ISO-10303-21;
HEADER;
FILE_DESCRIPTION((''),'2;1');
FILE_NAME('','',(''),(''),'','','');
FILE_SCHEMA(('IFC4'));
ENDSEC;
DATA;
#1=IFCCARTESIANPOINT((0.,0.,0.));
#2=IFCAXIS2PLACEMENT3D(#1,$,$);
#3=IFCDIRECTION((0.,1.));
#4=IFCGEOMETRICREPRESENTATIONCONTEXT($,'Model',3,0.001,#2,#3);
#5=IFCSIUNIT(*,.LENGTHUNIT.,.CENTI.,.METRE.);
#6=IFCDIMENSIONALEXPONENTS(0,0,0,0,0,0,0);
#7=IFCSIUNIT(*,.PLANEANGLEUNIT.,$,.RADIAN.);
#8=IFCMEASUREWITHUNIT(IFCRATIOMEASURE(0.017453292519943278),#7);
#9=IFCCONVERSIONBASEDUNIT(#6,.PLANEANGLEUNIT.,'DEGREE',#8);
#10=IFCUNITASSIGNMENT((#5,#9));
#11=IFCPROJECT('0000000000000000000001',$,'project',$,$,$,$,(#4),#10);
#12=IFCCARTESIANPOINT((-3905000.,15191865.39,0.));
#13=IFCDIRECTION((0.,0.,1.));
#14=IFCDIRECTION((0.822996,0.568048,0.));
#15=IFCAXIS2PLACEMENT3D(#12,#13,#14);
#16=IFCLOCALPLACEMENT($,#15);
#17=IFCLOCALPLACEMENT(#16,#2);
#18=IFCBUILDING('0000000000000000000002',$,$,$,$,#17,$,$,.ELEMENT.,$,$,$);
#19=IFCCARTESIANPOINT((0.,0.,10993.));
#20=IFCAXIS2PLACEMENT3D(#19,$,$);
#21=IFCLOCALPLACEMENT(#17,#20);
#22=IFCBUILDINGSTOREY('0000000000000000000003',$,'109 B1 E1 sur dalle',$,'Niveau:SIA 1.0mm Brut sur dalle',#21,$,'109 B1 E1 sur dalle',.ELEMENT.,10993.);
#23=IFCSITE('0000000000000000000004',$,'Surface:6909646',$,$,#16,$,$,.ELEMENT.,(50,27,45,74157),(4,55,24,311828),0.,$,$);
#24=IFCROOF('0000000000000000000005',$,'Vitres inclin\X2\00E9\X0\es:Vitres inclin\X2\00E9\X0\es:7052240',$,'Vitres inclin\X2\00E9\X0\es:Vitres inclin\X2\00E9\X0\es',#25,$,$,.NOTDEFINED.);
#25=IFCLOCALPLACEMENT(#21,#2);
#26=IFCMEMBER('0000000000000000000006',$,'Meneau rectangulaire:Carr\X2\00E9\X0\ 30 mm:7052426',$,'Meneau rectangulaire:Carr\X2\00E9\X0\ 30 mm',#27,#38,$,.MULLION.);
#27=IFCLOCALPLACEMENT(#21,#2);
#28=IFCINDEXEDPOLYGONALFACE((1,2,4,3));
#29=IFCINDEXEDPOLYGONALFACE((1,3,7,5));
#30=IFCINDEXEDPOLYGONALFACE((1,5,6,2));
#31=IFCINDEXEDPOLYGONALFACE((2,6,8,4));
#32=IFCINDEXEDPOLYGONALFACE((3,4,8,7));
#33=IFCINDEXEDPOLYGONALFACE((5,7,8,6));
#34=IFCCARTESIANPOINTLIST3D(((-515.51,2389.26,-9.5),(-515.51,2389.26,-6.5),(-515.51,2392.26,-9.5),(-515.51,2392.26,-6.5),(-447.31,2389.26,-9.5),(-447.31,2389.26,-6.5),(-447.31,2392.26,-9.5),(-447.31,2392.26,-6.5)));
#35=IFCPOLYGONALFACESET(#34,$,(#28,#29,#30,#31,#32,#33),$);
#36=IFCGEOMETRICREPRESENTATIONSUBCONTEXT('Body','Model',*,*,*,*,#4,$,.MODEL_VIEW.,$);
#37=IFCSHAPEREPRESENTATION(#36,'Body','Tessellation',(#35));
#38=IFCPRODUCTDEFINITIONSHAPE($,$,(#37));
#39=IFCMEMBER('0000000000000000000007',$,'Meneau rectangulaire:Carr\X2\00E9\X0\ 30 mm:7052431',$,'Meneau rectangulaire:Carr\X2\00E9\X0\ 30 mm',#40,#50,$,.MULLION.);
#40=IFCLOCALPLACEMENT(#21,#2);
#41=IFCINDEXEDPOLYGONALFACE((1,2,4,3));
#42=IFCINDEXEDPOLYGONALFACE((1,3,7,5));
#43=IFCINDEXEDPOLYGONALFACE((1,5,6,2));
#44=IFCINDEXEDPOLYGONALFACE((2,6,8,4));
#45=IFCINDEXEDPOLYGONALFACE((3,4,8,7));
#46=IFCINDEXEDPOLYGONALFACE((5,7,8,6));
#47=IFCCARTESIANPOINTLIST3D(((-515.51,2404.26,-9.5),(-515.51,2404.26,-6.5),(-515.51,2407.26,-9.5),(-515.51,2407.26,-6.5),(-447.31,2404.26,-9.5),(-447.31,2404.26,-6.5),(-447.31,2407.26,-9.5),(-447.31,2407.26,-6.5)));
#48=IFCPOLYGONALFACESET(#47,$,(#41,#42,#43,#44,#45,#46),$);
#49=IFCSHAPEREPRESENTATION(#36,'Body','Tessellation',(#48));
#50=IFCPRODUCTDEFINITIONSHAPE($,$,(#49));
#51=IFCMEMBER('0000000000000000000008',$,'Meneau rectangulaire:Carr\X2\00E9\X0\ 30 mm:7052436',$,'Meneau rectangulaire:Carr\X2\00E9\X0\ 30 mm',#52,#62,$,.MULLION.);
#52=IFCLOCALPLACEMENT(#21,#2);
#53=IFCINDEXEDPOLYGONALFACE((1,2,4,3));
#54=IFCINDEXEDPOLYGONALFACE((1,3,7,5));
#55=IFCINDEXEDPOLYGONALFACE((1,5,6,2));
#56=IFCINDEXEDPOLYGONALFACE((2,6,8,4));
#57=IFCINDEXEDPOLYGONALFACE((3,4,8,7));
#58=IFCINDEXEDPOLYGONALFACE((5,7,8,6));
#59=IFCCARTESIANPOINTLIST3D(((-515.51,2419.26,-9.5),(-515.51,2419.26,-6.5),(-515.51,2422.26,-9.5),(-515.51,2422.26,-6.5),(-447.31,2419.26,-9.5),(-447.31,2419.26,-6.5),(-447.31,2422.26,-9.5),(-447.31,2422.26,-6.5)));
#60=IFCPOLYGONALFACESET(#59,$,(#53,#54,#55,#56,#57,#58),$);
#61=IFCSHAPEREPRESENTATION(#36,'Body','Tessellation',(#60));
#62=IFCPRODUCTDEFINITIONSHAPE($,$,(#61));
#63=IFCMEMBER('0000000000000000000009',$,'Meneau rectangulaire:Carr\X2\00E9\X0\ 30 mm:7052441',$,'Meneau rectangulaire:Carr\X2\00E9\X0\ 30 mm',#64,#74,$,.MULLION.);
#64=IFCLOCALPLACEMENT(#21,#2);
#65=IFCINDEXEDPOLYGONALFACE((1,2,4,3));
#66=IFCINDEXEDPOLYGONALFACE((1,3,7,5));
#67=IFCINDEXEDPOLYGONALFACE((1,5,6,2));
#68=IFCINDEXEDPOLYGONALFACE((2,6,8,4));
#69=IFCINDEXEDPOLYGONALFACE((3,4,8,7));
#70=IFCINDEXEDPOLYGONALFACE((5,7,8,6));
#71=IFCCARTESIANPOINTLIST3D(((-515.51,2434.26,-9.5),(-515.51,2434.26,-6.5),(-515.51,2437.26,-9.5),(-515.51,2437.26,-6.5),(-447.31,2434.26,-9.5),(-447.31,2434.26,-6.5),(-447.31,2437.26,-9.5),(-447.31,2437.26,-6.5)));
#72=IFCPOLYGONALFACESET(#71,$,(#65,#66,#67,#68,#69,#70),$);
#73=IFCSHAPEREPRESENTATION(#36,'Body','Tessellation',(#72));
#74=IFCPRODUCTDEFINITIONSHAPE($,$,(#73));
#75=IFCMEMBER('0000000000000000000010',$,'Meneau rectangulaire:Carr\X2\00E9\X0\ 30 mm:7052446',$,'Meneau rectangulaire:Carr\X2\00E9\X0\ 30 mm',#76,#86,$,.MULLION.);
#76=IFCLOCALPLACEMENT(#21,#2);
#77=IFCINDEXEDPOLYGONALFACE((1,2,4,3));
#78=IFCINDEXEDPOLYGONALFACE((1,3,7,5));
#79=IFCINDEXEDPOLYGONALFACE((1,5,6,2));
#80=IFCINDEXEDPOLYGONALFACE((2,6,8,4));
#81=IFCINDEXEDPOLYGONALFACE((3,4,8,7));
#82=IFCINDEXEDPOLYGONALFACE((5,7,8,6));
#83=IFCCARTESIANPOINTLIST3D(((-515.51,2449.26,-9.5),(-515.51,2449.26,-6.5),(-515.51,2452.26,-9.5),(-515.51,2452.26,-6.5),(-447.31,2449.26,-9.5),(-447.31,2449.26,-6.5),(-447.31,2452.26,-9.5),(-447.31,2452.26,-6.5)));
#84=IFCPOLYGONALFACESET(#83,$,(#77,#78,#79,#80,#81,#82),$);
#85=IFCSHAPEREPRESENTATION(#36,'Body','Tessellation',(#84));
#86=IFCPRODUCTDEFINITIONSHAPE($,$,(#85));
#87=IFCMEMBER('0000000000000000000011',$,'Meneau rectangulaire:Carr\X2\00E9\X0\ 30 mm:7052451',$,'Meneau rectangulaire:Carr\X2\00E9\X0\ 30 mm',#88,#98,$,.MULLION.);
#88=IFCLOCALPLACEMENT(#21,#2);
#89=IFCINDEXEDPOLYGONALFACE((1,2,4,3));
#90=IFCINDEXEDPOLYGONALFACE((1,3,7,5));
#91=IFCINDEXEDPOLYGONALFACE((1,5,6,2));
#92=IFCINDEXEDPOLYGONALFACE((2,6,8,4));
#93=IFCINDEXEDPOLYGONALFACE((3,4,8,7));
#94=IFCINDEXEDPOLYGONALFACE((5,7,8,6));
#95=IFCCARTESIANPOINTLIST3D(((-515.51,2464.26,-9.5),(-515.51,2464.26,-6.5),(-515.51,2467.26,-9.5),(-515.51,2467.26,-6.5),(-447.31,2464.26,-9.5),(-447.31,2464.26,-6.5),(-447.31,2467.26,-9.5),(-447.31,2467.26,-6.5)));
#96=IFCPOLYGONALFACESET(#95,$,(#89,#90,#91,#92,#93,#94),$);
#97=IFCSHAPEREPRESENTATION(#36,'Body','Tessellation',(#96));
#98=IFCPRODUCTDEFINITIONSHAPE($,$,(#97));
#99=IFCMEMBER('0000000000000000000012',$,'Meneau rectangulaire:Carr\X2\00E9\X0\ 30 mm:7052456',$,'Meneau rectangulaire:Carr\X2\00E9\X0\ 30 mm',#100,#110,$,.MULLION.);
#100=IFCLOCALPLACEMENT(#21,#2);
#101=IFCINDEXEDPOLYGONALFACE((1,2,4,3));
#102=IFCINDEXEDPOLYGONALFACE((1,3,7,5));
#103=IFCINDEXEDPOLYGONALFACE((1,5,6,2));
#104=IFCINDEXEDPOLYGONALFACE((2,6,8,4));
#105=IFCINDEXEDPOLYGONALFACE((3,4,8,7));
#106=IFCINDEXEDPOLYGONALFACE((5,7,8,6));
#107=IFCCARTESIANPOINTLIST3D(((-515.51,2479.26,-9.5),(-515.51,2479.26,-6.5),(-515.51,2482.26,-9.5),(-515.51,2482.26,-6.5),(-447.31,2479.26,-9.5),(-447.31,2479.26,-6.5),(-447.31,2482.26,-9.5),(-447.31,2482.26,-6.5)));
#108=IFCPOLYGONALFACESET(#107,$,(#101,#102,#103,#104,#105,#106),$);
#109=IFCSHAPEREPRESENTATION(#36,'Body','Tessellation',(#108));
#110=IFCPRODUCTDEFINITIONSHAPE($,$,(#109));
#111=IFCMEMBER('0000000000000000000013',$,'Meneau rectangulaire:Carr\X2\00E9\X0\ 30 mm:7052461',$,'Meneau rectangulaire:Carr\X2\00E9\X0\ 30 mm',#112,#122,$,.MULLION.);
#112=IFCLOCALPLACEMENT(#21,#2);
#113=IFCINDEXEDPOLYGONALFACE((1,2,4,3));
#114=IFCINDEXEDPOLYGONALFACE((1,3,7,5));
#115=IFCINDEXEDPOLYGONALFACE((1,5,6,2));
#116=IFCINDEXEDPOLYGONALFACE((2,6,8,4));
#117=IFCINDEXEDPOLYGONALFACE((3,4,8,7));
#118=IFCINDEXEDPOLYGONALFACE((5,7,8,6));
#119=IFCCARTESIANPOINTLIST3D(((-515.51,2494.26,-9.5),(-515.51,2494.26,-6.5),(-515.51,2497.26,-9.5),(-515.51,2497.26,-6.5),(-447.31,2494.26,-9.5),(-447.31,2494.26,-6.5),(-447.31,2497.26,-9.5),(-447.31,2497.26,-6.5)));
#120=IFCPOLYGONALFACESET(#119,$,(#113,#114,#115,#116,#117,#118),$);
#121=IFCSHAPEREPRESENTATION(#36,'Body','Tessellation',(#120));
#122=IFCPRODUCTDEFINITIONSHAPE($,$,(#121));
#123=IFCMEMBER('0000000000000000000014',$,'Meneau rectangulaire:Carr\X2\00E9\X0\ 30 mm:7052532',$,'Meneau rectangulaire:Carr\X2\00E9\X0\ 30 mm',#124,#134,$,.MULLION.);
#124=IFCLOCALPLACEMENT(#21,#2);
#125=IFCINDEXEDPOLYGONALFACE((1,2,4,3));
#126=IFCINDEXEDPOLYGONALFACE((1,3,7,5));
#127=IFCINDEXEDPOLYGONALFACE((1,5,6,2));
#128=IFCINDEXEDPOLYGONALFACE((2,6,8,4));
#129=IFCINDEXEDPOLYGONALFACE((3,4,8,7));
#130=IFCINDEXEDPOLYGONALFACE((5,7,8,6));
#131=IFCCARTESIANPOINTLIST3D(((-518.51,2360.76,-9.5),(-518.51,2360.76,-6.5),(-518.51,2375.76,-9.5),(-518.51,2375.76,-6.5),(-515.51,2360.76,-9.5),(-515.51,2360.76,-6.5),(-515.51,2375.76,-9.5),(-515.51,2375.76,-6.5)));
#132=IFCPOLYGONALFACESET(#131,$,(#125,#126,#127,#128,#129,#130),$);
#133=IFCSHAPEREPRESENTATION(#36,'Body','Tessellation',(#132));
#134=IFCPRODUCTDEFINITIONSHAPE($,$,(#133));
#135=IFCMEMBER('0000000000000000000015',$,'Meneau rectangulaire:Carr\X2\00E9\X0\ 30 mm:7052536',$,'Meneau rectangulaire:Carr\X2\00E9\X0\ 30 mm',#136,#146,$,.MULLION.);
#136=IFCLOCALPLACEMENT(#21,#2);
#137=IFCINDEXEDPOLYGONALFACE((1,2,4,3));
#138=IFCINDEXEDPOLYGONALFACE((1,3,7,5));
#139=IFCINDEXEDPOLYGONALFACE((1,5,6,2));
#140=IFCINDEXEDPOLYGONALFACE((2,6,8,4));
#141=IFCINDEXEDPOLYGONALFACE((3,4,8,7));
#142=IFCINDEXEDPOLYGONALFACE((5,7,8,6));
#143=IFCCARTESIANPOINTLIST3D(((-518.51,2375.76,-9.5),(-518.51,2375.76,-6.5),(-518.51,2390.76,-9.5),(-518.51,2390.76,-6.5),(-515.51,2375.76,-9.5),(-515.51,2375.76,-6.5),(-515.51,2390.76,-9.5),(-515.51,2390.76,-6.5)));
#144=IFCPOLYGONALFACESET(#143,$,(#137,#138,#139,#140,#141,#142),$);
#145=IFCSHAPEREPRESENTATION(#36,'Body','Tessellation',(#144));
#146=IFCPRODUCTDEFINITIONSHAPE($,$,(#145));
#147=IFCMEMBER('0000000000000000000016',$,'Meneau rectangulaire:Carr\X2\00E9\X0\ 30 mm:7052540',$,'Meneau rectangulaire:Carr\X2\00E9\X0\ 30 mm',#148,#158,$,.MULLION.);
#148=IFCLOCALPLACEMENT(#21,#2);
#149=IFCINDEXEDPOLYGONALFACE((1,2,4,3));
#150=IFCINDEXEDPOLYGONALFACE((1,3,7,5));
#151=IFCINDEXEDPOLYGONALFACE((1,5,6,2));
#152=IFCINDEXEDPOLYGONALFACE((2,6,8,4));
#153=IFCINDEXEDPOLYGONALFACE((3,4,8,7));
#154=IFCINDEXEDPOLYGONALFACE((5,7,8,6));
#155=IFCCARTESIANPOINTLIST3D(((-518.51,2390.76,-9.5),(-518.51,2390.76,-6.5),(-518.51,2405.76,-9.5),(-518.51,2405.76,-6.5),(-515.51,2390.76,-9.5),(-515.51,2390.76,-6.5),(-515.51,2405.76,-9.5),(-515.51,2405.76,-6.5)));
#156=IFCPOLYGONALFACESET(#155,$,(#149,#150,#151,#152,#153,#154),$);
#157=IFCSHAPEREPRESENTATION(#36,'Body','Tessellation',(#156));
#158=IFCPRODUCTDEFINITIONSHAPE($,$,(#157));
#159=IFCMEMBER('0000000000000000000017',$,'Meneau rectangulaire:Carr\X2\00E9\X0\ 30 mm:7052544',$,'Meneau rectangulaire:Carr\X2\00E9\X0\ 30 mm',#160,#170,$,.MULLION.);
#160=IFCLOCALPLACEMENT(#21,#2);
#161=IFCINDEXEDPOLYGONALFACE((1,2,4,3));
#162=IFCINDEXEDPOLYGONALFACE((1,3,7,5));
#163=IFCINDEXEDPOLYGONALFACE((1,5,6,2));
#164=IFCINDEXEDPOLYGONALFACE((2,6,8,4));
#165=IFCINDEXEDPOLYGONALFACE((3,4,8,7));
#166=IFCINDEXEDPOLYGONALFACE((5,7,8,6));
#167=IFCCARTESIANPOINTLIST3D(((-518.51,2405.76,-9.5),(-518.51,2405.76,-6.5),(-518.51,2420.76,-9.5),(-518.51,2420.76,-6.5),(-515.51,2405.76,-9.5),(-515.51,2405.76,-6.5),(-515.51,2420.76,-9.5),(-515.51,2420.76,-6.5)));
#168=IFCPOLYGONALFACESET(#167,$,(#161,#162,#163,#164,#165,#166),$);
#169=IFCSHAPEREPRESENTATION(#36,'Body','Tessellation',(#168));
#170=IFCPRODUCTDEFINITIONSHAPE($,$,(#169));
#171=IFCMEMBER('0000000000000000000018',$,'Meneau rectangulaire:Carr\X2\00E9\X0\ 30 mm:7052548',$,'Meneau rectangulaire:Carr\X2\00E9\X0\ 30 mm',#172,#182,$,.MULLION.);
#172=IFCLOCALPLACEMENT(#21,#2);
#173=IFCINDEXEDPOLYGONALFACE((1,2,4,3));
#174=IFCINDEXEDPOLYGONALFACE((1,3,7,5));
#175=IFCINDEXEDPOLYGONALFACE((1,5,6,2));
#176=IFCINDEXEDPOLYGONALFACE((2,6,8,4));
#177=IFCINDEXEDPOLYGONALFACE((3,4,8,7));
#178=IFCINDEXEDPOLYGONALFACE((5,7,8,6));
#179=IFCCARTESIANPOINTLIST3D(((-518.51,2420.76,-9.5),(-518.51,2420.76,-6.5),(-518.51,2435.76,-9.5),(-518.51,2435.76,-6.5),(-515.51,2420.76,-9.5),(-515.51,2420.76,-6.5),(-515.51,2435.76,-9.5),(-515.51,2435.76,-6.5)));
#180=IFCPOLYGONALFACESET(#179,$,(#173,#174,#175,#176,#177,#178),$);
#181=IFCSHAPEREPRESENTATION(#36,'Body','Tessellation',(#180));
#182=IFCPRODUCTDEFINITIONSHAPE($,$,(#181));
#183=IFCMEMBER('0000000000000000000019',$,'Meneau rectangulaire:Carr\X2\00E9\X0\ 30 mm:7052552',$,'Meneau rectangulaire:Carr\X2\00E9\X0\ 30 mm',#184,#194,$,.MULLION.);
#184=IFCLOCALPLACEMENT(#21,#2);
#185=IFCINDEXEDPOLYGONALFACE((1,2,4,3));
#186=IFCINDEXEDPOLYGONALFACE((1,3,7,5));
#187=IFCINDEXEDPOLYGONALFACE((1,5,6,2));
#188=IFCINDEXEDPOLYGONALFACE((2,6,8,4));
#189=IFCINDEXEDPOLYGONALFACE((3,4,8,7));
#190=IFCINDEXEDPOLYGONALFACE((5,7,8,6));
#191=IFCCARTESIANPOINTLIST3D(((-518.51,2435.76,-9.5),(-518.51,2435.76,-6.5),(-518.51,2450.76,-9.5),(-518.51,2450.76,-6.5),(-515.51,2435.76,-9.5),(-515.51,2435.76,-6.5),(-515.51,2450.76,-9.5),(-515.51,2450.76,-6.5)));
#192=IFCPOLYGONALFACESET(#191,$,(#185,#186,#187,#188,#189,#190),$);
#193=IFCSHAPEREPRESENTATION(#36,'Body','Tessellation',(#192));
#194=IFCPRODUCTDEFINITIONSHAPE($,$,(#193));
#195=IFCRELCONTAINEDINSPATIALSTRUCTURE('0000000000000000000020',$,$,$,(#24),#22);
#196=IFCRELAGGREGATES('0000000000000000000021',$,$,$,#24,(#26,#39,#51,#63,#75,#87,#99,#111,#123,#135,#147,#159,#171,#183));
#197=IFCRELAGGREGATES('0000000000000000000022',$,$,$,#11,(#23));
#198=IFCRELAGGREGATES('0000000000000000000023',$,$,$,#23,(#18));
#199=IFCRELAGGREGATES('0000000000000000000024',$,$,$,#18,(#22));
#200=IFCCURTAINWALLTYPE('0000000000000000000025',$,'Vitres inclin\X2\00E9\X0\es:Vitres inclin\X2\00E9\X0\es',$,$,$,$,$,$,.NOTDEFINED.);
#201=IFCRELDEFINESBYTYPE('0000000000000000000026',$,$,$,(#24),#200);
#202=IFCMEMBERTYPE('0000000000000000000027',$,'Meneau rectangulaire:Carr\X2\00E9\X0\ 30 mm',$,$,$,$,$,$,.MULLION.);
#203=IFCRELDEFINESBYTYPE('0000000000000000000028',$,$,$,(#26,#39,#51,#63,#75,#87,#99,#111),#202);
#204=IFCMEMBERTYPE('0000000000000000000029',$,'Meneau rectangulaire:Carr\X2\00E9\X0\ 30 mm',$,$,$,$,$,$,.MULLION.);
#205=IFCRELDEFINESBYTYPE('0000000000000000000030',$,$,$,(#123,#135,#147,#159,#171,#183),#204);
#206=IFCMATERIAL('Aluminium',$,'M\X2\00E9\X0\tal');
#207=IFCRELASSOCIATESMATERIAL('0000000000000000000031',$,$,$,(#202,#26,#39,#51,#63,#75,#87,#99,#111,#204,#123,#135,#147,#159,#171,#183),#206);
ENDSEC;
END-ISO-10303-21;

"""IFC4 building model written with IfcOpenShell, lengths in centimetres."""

from ifc_helpers import new_model, entity, si_unit, converted_unit, direction, frame, origin, place, context, subcontext, project, spatial, indexed_curve, outline, extrude, source, transform, mapped, material, type_object, type_shapes, element, aggregate, save


model = new_model("IFC4")

# Units and contexts
model_context = context("Model", 3, precision=0.001, world=origin(), true_north=direction((0.0, 1.0)))
body_context = subcontext(model_context, "Body", "Model", "MODEL_VIEW")
ifc_project = project(units=[si_unit("LENGTHUNIT", "METRE", prefix="CENTI"), converted_unit("PLANEANGLEUNIT", "DEGREE", entity("IfcRatioMeasure", 0.017453292519943278), si_unit("PLANEANGLEUNIT", "RADIAN"), dimensions=[0, 0, 0, 0, 0, 0, 0])], contexts=[model_context])

# Site, building, storey
site_placement = place(None, frame((-3905000.0, 15191865.39, 0.0), z_axis=(0.0, 0.0, 1.0), x_axis=(0.822996, 0.568048, 0.0)))
site = spatial("IfcSite", under=ifc_project, at=site_placement, Name="Surface:6909646", CompositionType="ELEMENT", RefLatitude=(50, 27, 45, 74157), RefLongitude=(4, 55, 24, 311828), RefElevation=0.0)
building_placement = place(site_placement, origin())
building = spatial("IfcBuilding", under=site, at=building_placement, CompositionType="ELEMENT")
storey_placement = place(building_placement, frame((0.0, 0.0, 10993.0)))
storey = spatial("IfcBuildingStorey", under=building, at=storey_placement, Name="109 B1 E1 sur dalle", ObjectType="Niveau:SIA 1.0mm Brut sur dalle", LongName="109 B1 E1 sur dalle", CompositionType="ELEMENT", Elevation=10993.0)

# Roof, members
curtain_wall_type = type_object("IfcCurtainWallType", Name="Vitres inclinées:Vitres inclinées", PredefinedType="NOTDEFINED")
roof_placement = place(storey_placement, frame((0.0, 0.0, -10993.0)))
roof = element("IfcRoof", 1, at=roof_placement, inside=storey, type_object=curtain_wall_type, Name="Vitres inclinées:Vitres inclinées:7052240", ObjectType="Vitres inclinées:Vitres inclinées", PredefinedType="NOTDEFINED")
ifc_material = material(Name="Aluminium", Category="Métal")
member_type_1 = type_object("IfcMemberType", Name="Meneau rectangulaire:Carré 30 mm", PredefinedType="MULLION", material=ifc_material)
shared_shape_1 = source(origin(), body_context, "Body", "SweptSolid", [
    extrude(outline(indexed_curve([(-1.5, -1.5), (1.5, -1.5), (1.5, 1.5), (-1.5, 1.5), (-1.5, -1.5)], self_intersect=False)), frame((0.0, 0.0, -68.2), z_axis=(0.0, 0.0, 1.0), x_axis=(0.0, -1.0, 0.0)), (0.0, 0.0, 1.0), 68.2),
])
type_shapes(member_type_1, [shared_shape_1])
member_1_placement = place(roof_placement, frame((-515.51, 2390.76, 10985.0), z_axis=(-1.0, 0.0, 0.0), x_axis=(0.0, 1.0, 0.0)))
member_1 = element("IfcMember", 2, at=member_1_placement, type_object=member_type_1, material=ifc_material, Name="Meneau rectangulaire:Carré 30 mm:7052426", ObjectType="Meneau rectangulaire:Carré 30 mm", PredefinedType="MULLION", context=body_context, shape_type="MappedRepresentation", body=[
    mapped(shared_shape_1, transform((0.0, 0.0, 0.0), scale=1.0)),
])
member_2_placement = place(roof_placement, frame((-515.51, 2405.76, 10985.0), z_axis=(-1.0, 0.0, 0.0), x_axis=(0.0, 1.0, 0.0)))
member_2 = element("IfcMember", 3, at=member_2_placement, type_object=member_type_1, material=ifc_material, Name="Meneau rectangulaire:Carré 30 mm:7052431", ObjectType="Meneau rectangulaire:Carré 30 mm", PredefinedType="MULLION", context=body_context, shape_type="MappedRepresentation", body=[
    mapped(shared_shape_1, transform((0.0, 0.0, 0.0), scale=1.0)),
])
member_3_placement = place(roof_placement, frame((-515.51, 2420.76, 10985.0), z_axis=(-1.0, 0.0, 0.0), x_axis=(0.0, 1.0, 0.0)))
member_3 = element("IfcMember", 4, at=member_3_placement, type_object=member_type_1, material=ifc_material, Name="Meneau rectangulaire:Carré 30 mm:7052436", ObjectType="Meneau rectangulaire:Carré 30 mm", PredefinedType="MULLION", context=body_context, shape_type="MappedRepresentation", body=[
    mapped(shared_shape_1, transform((0.0, 0.0, 0.0), scale=1.0)),
])
member_4_placement = place(roof_placement, frame((-515.51, 2435.76, 10985.0), z_axis=(-1.0, 0.0, 0.0), x_axis=(0.0, 1.0, 0.0)))
member_4 = element("IfcMember", 5, at=member_4_placement, type_object=member_type_1, material=ifc_material, Name="Meneau rectangulaire:Carré 30 mm:7052441", ObjectType="Meneau rectangulaire:Carré 30 mm", PredefinedType="MULLION", context=body_context, shape_type="MappedRepresentation", body=[
    mapped(shared_shape_1, transform((0.0, 0.0, 0.0), scale=1.0)),
])
member_5_placement = place(roof_placement, frame((-515.51, 2450.76, 10985.0), z_axis=(-1.0, 0.0, 0.0), x_axis=(0.0, 1.0, 0.0)))
member_5 = element("IfcMember", 6, at=member_5_placement, type_object=member_type_1, material=ifc_material, Name="Meneau rectangulaire:Carré 30 mm:7052446", ObjectType="Meneau rectangulaire:Carré 30 mm", PredefinedType="MULLION", context=body_context, shape_type="MappedRepresentation", body=[
    mapped(shared_shape_1, transform((0.0, 0.0, 0.0), scale=1.0)),
])
member_6_placement = place(roof_placement, frame((-515.51, 2465.76, 10985.0), z_axis=(-1.0, 0.0, 0.0), x_axis=(0.0, 1.0, 0.0)))
member_6 = element("IfcMember", 7, at=member_6_placement, type_object=member_type_1, material=ifc_material, Name="Meneau rectangulaire:Carré 30 mm:7052451", ObjectType="Meneau rectangulaire:Carré 30 mm", PredefinedType="MULLION", context=body_context, shape_type="MappedRepresentation", body=[
    mapped(shared_shape_1, transform((0.0, 0.0, 0.0), scale=1.0)),
])
member_7_placement = place(roof_placement, frame((-515.51, 2480.76, 10985.0), z_axis=(-1.0, 0.0, 0.0), x_axis=(0.0, 1.0, 0.0)))
member_7 = element("IfcMember", 8, at=member_7_placement, type_object=member_type_1, material=ifc_material, Name="Meneau rectangulaire:Carré 30 mm:7052456", ObjectType="Meneau rectangulaire:Carré 30 mm", PredefinedType="MULLION", context=body_context, shape_type="MappedRepresentation", body=[
    mapped(shared_shape_1, transform((0.0, 0.0, 0.0), scale=1.0)),
])
member_8_placement = place(roof_placement, frame((-515.51, 2495.76, 10985.0), z_axis=(-1.0, 0.0, 0.0), x_axis=(0.0, 1.0, 0.0)))
member_8 = element("IfcMember", 9, at=member_8_placement, type_object=member_type_1, material=ifc_material, Name="Meneau rectangulaire:Carré 30 mm:7052461", ObjectType="Meneau rectangulaire:Carré 30 mm", PredefinedType="MULLION", context=body_context, shape_type="MappedRepresentation", body=[
    mapped(shared_shape_1, transform((0.0, 0.0, 0.0), scale=1.0)),
])
member_type_2 = type_object("IfcMemberType", Name="Meneau rectangulaire:Carré 30 mm", PredefinedType="MULLION", material=ifc_material)
shared_shape_2 = source(origin(), body_context, "Body", "SweptSolid", [
    extrude(outline(indexed_curve([(-1.5, -1.5), (1.5, -1.5), (1.5, 1.5), (-1.5, 1.5), (-1.5, -1.5)], self_intersect=False)), frame((0.0, 0.0, -15.0), z_axis=(0.0, 0.0, 1.0), x_axis=(0.0, -1.0, 0.0)), (0.0, 0.0, 1.0), 15.0),
])
type_shapes(member_type_2, [shared_shape_2])
member_9_placement = place(roof_placement, frame((-517.01, 2375.76, 10985.0), z_axis=(0.0, 1.0, 0.0), x_axis=(1.0, 0.0, 0.0)))
member_9 = element("IfcMember", 10, at=member_9_placement, type_object=member_type_2, material=ifc_material, Name="Meneau rectangulaire:Carré 30 mm:7052532", ObjectType="Meneau rectangulaire:Carré 30 mm", PredefinedType="MULLION", context=body_context, shape_type="MappedRepresentation", body=[
    mapped(shared_shape_2, transform((0.0, 0.0, 0.0), scale=1.0)),
])
member_10_placement = place(roof_placement, frame((-517.01, 2390.76, 10985.0), z_axis=(0.0, 1.0, 0.0), x_axis=(1.0, 0.0, 0.0)))
member_10 = element("IfcMember", 11, at=member_10_placement, type_object=member_type_2, material=ifc_material, Name="Meneau rectangulaire:Carré 30 mm:7052536", ObjectType="Meneau rectangulaire:Carré 30 mm", PredefinedType="MULLION", context=body_context, shape_type="MappedRepresentation", body=[
    mapped(shared_shape_2, transform((0.0, 0.0, 0.0), scale=1.0)),
])
member_11_placement = place(roof_placement, frame((-517.01, 2405.76, 10985.0), z_axis=(0.0, 1.0, 0.0), x_axis=(1.0, 0.0, 0.0)))
member_11 = element("IfcMember", 12, at=member_11_placement, type_object=member_type_2, material=ifc_material, Name="Meneau rectangulaire:Carré 30 mm:7052540", ObjectType="Meneau rectangulaire:Carré 30 mm", PredefinedType="MULLION", context=body_context, shape_type="MappedRepresentation", body=[
    mapped(shared_shape_2, transform((0.0, 0.0, 0.0), scale=1.0)),
])
member_12_placement = place(roof_placement, frame((-517.01, 2420.76, 10985.0), z_axis=(0.0, 1.0, 0.0), x_axis=(1.0, 0.0, 0.0)))
member_12 = element("IfcMember", 13, at=member_12_placement, type_object=member_type_2, material=ifc_material, Name="Meneau rectangulaire:Carré 30 mm:7052544", ObjectType="Meneau rectangulaire:Carré 30 mm", PredefinedType="MULLION", context=body_context, shape_type="MappedRepresentation", body=[
    mapped(shared_shape_2, transform((0.0, 0.0, 0.0), scale=1.0)),
])
member_13_placement = place(roof_placement, frame((-517.01, 2435.76, 10985.0), z_axis=(0.0, 1.0, 0.0), x_axis=(1.0, 0.0, 0.0)))
member_13 = element("IfcMember", 14, at=member_13_placement, type_object=member_type_2, material=ifc_material, Name="Meneau rectangulaire:Carré 30 mm:7052548", ObjectType="Meneau rectangulaire:Carré 30 mm", PredefinedType="MULLION", context=body_context, shape_type="MappedRepresentation", body=[
    mapped(shared_shape_2, transform((0.0, 0.0, 0.0), scale=1.0)),
])
member_14_placement = place(roof_placement, frame((-517.01, 2450.76, 10985.0), z_axis=(0.0, 1.0, 0.0), x_axis=(1.0, 0.0, 0.0)))
member_14 = element("IfcMember", 15, at=member_14_placement, type_object=member_type_2, material=ifc_material, Name="Meneau rectangulaire:Carré 30 mm:7052552", ObjectType="Meneau rectangulaire:Carré 30 mm", PredefinedType="MULLION", context=body_context, shape_type="MappedRepresentation", body=[
    mapped(shared_shape_2, transform((0.0, 0.0, 0.0), scale=1.0)),
])
aggregate(roof, [member_1, member_2, member_3, member_4, member_5, member_6, member_7, member_8, member_9, member_10, member_11, member_12, member_13, member_14])

save(model, "model.ifc")
